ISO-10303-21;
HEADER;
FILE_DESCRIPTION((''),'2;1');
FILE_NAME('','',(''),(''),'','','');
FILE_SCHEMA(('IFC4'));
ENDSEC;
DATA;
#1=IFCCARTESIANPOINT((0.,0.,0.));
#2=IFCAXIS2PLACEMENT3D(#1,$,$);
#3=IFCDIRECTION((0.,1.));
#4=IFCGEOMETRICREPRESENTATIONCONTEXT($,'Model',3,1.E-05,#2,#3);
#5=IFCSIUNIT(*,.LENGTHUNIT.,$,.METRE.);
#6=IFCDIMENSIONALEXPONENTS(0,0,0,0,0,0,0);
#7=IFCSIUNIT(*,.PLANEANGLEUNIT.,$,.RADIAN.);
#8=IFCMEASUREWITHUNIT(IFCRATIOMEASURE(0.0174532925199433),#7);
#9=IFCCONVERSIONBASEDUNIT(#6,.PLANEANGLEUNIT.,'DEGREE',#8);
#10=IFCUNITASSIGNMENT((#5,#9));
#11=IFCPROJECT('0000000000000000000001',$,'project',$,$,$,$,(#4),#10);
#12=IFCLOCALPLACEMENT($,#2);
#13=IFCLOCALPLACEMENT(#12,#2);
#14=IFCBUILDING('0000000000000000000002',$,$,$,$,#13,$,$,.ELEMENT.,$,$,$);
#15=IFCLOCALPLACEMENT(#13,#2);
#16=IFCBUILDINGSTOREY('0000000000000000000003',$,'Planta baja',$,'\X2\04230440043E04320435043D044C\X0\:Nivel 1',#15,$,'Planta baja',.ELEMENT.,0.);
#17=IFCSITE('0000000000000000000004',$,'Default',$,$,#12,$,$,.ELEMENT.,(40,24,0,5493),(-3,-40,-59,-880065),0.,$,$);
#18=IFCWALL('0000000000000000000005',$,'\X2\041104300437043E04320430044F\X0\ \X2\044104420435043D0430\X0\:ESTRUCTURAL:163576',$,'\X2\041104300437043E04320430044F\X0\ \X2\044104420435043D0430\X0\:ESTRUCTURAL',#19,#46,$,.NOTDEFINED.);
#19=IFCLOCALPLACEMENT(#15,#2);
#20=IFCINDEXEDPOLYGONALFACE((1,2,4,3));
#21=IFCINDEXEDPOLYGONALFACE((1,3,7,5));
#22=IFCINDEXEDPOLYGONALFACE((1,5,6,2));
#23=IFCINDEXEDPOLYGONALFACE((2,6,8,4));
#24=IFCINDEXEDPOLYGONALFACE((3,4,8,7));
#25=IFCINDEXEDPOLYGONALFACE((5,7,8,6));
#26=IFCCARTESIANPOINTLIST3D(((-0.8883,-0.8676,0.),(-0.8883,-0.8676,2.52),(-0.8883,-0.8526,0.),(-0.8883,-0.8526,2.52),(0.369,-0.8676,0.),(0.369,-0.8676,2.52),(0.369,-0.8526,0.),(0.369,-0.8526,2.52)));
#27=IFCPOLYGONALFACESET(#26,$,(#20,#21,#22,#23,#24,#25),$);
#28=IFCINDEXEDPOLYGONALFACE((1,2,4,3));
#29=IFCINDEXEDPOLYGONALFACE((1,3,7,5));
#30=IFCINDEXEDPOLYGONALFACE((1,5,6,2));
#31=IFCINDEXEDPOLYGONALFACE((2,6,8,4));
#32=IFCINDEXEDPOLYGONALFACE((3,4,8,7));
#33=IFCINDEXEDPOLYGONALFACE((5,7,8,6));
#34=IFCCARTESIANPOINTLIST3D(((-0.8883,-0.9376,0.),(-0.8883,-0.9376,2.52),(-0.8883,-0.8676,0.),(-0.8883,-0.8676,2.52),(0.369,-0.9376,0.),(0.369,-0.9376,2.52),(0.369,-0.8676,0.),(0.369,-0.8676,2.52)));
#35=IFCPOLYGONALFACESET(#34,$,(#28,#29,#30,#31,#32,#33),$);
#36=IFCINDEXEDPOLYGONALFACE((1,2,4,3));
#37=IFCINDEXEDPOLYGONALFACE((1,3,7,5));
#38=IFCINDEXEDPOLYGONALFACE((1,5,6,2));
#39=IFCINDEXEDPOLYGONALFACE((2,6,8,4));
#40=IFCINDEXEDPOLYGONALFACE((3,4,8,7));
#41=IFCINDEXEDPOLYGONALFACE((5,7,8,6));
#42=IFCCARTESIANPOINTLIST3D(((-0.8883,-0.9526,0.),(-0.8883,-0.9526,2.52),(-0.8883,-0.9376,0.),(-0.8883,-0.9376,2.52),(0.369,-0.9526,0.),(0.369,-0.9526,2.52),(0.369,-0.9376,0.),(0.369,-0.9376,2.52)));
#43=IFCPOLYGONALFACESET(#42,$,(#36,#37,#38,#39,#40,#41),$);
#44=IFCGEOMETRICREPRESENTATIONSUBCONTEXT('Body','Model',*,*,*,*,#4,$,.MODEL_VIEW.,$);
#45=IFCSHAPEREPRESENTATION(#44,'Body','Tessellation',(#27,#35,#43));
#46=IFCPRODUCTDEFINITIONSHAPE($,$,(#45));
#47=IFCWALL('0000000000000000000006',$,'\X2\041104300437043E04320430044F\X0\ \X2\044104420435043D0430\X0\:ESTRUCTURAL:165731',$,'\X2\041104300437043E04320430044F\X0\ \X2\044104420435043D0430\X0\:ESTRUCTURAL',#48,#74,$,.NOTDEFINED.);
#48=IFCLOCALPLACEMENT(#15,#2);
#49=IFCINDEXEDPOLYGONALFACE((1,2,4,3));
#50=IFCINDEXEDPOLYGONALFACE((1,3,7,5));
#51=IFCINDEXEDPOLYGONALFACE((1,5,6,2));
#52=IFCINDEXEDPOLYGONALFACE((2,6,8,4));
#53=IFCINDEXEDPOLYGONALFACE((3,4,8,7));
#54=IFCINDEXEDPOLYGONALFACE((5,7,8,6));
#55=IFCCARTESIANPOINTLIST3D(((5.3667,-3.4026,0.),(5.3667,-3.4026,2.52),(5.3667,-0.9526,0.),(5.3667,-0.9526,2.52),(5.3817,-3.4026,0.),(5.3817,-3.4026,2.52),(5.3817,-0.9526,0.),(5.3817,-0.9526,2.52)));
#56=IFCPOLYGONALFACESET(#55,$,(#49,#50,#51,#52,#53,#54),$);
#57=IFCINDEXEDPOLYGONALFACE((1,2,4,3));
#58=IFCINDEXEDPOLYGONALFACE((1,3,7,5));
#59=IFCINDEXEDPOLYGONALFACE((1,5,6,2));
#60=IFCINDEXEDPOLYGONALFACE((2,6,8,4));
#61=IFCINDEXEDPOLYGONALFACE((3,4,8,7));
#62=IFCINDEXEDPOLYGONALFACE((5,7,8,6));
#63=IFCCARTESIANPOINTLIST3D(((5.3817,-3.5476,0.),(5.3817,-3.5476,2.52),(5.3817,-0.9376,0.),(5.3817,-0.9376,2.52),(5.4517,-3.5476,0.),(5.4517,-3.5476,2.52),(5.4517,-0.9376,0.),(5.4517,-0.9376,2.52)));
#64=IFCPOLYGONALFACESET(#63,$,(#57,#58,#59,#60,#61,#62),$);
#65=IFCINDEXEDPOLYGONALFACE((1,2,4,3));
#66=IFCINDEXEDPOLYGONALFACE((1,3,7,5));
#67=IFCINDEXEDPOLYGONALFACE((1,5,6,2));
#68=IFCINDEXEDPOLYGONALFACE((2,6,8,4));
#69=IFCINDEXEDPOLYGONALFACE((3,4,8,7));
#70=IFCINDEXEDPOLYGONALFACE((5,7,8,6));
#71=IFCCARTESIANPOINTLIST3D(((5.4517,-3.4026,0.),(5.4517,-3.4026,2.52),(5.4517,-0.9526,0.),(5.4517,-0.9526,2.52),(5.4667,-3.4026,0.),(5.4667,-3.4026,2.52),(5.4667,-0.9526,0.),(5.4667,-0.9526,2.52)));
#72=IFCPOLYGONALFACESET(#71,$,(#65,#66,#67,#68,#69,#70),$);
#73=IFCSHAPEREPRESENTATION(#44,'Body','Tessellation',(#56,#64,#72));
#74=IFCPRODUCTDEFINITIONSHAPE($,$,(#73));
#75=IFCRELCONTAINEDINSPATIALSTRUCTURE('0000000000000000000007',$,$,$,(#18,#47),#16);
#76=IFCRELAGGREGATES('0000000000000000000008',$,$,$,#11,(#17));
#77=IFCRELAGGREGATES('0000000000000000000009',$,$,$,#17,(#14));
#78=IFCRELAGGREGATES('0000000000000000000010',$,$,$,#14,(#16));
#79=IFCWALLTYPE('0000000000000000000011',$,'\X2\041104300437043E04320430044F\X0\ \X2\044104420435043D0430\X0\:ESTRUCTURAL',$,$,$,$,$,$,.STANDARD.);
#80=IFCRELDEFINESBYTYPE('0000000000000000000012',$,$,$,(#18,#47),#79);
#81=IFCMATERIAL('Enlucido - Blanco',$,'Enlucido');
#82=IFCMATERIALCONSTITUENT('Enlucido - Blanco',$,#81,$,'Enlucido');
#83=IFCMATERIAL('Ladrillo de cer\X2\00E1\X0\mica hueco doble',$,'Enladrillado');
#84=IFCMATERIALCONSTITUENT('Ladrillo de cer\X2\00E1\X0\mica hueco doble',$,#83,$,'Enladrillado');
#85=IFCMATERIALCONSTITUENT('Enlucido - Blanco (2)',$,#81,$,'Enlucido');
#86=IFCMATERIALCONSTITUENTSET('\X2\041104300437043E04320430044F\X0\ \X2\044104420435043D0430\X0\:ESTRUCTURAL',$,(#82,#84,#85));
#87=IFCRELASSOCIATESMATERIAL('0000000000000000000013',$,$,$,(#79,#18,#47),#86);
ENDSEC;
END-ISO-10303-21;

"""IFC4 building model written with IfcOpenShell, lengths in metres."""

from ifc_helpers import new_model, entity, si_unit, converted_unit, direction, frame, origin, place, context, subcontext, project, spatial, indexed_curve, outline, extrude, material, constituent, constituent_set, type_object, element, save


model = new_model("IFC4")

# Units and contexts
model_context = context("Model", 3, precision=1e-05, world=origin(), true_north=direction((0.0, 1.0)))
body_context = subcontext(model_context, "Body", "Model", "MODEL_VIEW")
ifc_project = project(units=[si_unit("LENGTHUNIT", "METRE"), converted_unit("PLANEANGLEUNIT", "DEGREE", entity("IfcRatioMeasure", 0.0174532925199433), si_unit("PLANEANGLEUNIT", "RADIAN"), dimensions=[0, 0, 0, 0, 0, 0, 0])], contexts=[model_context])

# Site, building, storey
site_placement = place(None, origin())
site = spatial("IfcSite", under=ifc_project, at=site_placement, Name="Default", CompositionType="ELEMENT", RefLatitude=(40, 24, 0, 5493), RefLongitude=(-3, -40, -59, -880065), RefElevation=0.0)
building_placement = place(site_placement, origin())
building = spatial("IfcBuilding", under=site, at=building_placement, CompositionType="ELEMENT")
storey_placement = place(building_placement, origin())
storey = spatial("IfcBuildingStorey", under=building, at=storey_placement, Name="Planta baja", ObjectType="Уровень:Nivel 1", LongName="Planta baja", CompositionType="ELEMENT", Elevation=0.0)

# Shared definitions
ifc_material_1 = material(Name="Enlucido - Blanco", Category="Enlucido")

# Shared definitions
ifc_material_2 = material(Name="Ladrillo de cerámica hueco doble", Category="Enladrillado")

# Wall
ifc_constituent_1 = constituent(ifc_material_1, Name="Enlucido - Blanco", Category="Enlucido")
ifc_constituent_2 = constituent(ifc_material_2, Name="Ladrillo de cerámica hueco doble", Category="Enladrillado")
ifc_constituent_3 = constituent(ifc_material_1, Name="Enlucido - Blanco (2)", Category="Enlucido")
ifc_constituent_set_1 = constituent_set(constituents=[ifc_constituent_1, ifc_constituent_2, ifc_constituent_3], Name="Базовая стена:ESTRUCTURAL")
wall_type_1 = type_object("IfcWallType", Name="Базовая стена:ESTRUCTURAL", PredefinedType="STANDARD", material=ifc_constituent_set_1)
wall_1_placement = place(storey_placement, frame((-0.8883, -0.9026, 0.0)))
element("IfcWall", 1, at=wall_1_placement, inside=storey, type_object=wall_type_1, material=ifc_constituent_set_1, Name="Базовая стена:ESTRUCTURAL:163576", ObjectType="Базовая стена:ESTRUCTURAL", PredefinedType="NOTDEFINED", context=body_context, shape_type="SweptSolid", body=[
    extrude(outline(indexed_curve([(-0.0075, -0.6287), (0.0075, -0.6287), (0.0075, 0.6287), (-0.0075, 0.6287), (-0.0075, -0.6287)], self_intersect=False)), frame((0.6287, 0.0425, 0.0), z_axis=(0.0, 0.0, 1.0), x_axis=(0.0, -1.0, 0.0)), (0.0, 0.0, 1.0), 2.52),
    extrude(outline(indexed_curve([(-0.6287, -0.035), (0.6287, -0.035), (0.6287, 0.035), (-0.6287, 0.035), (-0.6287, -0.035)], self_intersect=False)), frame((0.6287, 0.0, 0.0)), (0.0, 0.0, 1.0), 2.52),
    extrude(outline(indexed_curve([(-0.0075, -0.6287), (0.0075, -0.6287), (0.0075, 0.6287), (-0.0075, 0.6287), (-0.0075, -0.6287)], self_intersect=False)), frame((0.6287, -0.0425, 0.0), z_axis=(0.0, 0.0, 1.0), x_axis=(0.0, 1.0, 0.0)), (0.0, 0.0, 1.0), 2.52),
])

# Wall
wall_2_placement = place(storey_placement, frame((5.4167, -3.4026, 0.0), z_axis=(0.0, 0.0, 1.0), x_axis=(0.0, 1.0, 0.0)))
element("IfcWall", 2, at=wall_2_placement, inside=storey, type_object=wall_type_1, material=ifc_constituent_set_1, Name="Базовая стена:ESTRUCTURAL:165731", ObjectType="Базовая стена:ESTRUCTURAL", PredefinedType="NOTDEFINED", context=body_context, shape_type="SweptSolid", body=[
    extrude(outline(indexed_curve([(-0.0075, -1.225), (0.0075, -1.225), (0.0075, 1.225), (-0.0075, 1.225), (-0.0075, -1.225)], self_intersect=False)), frame((1.225, 0.0425, 0.0), z_axis=(0.0, 0.0, 1.0), x_axis=(0.0, -1.0, 0.0)), (0.0, 0.0, 1.0), 2.52),
    extrude(outline(indexed_curve([(-1.305, -0.035), (1.305, -0.035), (1.305, 0.035), (-1.305, 0.035), (-1.305, -0.035)], self_intersect=False)), frame((1.16, 0.0, 0.0)), (0.0, 0.0, 1.0), 2.52),
    extrude(outline(indexed_curve([(-0.0075, -1.225), (0.0075, -1.225), (0.0075, 1.225), (-0.0075, 1.225), (-0.0075, -1.225)], self_intersect=False)), frame((1.225, -0.0425, 0.0), z_axis=(0.0, 0.0, 1.0), x_axis=(0.0, 1.0, 0.0)), (0.0, 0.0, 1.0), 2.52),
])

save(model, "model.ifc")
